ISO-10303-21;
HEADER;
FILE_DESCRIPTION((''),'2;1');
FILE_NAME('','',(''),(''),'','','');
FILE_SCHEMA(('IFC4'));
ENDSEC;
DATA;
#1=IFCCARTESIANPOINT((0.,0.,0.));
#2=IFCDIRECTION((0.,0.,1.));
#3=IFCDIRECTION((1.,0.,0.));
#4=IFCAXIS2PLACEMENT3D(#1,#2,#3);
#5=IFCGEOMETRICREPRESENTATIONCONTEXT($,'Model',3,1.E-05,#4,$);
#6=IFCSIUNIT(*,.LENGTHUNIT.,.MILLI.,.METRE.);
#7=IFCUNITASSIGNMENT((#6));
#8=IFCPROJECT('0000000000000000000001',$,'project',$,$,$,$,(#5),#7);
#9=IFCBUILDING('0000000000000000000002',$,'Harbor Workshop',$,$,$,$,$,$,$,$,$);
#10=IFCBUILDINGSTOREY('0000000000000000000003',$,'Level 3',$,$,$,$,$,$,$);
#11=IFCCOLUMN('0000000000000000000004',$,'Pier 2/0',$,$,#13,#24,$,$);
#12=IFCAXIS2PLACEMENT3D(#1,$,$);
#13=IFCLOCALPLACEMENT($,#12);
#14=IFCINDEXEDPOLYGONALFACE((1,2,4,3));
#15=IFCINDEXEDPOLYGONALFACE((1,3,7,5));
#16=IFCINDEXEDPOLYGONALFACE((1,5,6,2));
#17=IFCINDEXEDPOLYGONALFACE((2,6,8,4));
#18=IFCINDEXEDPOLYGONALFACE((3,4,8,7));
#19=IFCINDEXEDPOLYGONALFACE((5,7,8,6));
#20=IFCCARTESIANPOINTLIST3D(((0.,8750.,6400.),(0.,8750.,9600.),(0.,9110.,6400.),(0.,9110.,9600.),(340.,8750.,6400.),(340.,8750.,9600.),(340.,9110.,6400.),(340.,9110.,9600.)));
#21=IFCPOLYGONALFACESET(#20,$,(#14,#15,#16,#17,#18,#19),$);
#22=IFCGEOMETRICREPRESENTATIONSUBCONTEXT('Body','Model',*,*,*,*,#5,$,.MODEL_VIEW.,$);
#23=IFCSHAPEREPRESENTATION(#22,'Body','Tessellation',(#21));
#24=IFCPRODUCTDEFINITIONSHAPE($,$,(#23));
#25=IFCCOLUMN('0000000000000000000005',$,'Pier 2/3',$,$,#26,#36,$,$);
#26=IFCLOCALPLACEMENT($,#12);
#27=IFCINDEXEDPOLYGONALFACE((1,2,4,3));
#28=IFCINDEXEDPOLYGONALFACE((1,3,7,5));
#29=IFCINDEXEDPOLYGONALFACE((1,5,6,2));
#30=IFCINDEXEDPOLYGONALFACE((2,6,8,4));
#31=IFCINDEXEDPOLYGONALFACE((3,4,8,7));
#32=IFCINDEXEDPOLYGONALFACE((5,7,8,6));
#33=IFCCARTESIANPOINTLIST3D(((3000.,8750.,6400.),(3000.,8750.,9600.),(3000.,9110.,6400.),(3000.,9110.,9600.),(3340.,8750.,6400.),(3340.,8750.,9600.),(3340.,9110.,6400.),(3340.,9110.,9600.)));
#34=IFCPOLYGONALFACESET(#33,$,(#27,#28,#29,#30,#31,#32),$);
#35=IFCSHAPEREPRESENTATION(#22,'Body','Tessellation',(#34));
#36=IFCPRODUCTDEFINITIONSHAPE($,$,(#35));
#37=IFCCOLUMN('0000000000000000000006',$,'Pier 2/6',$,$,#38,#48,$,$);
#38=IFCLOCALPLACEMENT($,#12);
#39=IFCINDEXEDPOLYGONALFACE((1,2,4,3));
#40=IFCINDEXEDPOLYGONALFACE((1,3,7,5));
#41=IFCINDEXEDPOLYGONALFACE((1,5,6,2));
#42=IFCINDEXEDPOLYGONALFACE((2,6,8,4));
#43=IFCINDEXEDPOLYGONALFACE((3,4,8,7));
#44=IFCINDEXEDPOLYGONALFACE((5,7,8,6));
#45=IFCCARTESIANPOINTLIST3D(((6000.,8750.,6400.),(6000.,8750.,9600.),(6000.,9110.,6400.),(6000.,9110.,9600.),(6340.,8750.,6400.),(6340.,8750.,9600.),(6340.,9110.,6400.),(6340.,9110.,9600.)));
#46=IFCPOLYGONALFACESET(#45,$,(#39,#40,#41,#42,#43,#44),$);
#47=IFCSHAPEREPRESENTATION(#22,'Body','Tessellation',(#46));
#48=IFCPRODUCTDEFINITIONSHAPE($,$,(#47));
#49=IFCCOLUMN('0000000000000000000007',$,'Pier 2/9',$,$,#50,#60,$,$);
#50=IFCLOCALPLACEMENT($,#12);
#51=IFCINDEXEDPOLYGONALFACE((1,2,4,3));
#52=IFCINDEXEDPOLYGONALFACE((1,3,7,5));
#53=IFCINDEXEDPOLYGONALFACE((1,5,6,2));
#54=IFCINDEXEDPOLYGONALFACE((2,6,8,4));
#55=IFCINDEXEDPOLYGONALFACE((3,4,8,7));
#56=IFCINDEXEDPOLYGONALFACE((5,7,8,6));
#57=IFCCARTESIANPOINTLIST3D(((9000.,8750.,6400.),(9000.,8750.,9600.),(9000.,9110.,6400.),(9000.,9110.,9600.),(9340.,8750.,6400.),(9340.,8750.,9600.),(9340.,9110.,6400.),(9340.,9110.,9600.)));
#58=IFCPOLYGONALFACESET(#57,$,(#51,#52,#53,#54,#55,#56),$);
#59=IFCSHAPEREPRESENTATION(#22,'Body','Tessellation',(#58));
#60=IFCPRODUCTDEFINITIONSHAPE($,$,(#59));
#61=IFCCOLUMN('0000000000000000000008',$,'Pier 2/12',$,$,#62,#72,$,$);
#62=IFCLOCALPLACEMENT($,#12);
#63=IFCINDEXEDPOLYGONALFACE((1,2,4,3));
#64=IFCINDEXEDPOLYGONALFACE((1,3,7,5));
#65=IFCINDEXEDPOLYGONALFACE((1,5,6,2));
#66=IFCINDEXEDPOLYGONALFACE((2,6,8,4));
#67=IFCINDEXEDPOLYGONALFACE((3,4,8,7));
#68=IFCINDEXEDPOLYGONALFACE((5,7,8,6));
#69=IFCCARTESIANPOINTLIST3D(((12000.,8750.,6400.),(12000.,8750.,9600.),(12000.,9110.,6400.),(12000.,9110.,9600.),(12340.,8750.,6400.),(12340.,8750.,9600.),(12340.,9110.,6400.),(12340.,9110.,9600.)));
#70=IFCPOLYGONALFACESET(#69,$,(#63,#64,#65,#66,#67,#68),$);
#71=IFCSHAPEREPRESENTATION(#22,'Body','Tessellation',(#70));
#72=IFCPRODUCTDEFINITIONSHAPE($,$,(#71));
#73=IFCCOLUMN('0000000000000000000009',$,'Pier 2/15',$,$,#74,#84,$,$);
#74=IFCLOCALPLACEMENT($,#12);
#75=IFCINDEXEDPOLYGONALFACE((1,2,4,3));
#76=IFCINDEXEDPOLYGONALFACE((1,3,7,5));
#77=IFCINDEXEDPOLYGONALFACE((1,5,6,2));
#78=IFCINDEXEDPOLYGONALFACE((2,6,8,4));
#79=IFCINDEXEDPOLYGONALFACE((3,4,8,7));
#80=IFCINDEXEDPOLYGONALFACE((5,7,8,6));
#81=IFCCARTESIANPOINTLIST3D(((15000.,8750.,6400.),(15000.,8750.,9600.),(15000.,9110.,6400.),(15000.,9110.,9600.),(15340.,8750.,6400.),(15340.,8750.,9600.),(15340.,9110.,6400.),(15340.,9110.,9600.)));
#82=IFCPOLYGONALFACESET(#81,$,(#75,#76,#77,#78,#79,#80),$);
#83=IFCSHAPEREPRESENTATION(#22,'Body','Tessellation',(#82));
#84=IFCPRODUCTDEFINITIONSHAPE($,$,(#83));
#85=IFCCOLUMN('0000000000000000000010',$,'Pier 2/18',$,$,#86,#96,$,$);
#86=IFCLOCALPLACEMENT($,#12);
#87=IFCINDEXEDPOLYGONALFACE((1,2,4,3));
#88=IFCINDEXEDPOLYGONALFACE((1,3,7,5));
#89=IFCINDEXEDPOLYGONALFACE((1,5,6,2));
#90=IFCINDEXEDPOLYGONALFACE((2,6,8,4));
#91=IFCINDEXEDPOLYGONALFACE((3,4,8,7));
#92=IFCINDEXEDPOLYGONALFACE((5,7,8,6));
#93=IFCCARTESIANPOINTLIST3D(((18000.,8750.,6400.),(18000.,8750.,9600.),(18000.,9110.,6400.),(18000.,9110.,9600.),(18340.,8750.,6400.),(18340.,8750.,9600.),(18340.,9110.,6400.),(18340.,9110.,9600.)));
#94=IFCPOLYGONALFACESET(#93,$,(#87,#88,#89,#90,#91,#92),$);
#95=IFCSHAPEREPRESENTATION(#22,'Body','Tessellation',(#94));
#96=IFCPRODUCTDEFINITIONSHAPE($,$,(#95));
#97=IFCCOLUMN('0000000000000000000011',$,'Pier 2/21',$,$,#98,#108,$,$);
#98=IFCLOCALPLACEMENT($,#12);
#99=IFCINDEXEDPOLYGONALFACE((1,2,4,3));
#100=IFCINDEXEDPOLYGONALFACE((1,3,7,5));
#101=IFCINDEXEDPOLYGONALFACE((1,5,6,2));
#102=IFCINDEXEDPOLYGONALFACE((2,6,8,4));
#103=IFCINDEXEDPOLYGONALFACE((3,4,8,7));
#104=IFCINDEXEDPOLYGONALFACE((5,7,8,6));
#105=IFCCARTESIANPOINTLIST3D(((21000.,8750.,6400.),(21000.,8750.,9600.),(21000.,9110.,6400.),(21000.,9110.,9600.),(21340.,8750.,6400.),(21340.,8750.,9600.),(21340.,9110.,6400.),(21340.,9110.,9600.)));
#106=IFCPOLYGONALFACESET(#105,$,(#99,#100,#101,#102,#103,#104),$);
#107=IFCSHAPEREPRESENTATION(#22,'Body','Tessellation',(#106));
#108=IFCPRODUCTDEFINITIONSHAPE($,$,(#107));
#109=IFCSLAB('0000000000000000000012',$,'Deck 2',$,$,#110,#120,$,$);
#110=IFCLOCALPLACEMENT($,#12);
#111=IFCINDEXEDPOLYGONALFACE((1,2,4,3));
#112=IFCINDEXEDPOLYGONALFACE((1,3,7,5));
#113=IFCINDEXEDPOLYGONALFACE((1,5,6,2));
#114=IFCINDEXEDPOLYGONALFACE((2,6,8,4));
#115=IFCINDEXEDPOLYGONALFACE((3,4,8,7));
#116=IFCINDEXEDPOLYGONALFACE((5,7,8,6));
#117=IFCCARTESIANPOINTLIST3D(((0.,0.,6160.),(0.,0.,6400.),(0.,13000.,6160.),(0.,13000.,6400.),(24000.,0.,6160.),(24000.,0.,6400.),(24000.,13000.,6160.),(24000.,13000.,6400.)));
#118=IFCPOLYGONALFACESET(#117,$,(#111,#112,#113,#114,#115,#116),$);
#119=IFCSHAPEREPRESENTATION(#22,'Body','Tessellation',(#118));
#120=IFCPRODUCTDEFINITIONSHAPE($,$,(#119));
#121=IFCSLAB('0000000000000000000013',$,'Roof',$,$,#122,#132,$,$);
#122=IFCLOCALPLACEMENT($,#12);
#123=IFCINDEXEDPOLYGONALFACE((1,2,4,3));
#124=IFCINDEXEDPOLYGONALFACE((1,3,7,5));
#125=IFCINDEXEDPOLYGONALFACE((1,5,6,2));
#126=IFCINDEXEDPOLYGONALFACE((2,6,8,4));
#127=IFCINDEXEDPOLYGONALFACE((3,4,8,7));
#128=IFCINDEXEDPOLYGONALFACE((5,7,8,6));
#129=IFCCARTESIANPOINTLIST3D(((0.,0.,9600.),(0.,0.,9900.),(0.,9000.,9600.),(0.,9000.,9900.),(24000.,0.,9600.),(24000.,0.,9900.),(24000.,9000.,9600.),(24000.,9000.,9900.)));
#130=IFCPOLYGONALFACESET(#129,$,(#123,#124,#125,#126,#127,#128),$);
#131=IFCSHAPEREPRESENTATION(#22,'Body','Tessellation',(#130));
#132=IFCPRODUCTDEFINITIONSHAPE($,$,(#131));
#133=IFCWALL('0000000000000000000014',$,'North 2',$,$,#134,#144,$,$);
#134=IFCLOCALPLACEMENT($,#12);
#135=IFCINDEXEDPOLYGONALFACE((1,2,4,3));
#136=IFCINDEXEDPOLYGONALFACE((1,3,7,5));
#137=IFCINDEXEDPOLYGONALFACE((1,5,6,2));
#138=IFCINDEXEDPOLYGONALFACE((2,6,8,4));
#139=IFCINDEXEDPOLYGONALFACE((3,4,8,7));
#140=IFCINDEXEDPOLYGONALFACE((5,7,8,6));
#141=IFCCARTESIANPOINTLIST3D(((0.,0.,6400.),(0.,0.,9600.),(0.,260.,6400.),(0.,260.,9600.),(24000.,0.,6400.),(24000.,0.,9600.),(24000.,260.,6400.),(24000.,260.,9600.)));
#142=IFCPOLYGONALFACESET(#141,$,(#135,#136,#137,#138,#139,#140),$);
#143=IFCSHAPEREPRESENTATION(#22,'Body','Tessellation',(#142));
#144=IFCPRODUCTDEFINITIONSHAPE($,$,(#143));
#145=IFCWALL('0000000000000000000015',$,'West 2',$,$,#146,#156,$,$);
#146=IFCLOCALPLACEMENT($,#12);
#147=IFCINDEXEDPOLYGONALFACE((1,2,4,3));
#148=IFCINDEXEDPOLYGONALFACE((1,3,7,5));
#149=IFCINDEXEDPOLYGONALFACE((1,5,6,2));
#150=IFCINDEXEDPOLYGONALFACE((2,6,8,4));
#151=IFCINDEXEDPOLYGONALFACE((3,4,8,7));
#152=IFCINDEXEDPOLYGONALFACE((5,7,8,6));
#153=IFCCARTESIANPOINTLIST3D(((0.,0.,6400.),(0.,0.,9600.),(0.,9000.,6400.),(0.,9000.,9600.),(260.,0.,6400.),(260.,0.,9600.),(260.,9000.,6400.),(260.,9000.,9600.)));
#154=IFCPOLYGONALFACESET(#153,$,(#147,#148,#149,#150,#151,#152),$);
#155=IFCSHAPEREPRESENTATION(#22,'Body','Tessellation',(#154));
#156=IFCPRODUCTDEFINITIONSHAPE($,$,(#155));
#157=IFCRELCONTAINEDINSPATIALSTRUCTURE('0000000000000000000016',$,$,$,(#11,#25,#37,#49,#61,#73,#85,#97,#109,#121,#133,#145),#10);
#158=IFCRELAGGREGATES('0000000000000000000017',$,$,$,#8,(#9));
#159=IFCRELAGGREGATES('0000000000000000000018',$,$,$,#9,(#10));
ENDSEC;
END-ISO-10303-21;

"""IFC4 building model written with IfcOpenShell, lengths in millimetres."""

from ifc_helpers import new_model, si_unit, frame, origin_with_axes, place, context, subcontext, project, spatial, indexed_curve, outline, extrude, element, save


model = new_model("IFC4")

# Units and contexts
model_context = context("Model", 3, precision=1e-05, world=origin_with_axes())
body_context = subcontext(model_context, "Body", "Model", "MODEL_VIEW")
ifc_project = project(units=[si_unit("LENGTHUNIT", "METRE", prefix="MILLI")], contexts=[model_context])

# Building, storey
building = spatial("IfcBuilding", under=ifc_project, Name="Harbor Workshop")
storey = spatial("IfcBuildingStorey", under=building, Name="Level 3")

# Columns
for number, where, z_axis, x_axis, name in (
    (1, (0.0, 8750.0, 6400.0), (0.0, 0.0, 1.0), (1.0, 0.0, 0.0), "Pier 2/0"),
    (2, (3000.0, 8750.0, 6400.0), (0.0, 0.0, 1.0), (1.0, 0.0, 0.0), "Pier 2/3"),
    (3, (6000.0, 8750.0, 6400.0), (0.0, 0.0, 1.0), (1.0, 0.0, 0.0), "Pier 2/6"),
    (4, (9000.0, 8750.0, 6400.0), (0.0, 0.0, 1.0), (1.0, 0.0, 0.0), "Pier 2/9"),
    (5, (12000.0, 8750.0, 6400.0), (0.0, 0.0, 1.0), (1.0, 0.0, 0.0), "Pier 2/12"),
    (6, (15000.0, 8750.0, 6400.0), (0.0, 0.0, 1.0), (1.0, 0.0, 0.0), "Pier 2/15"),
    (7, (18000.0, 8750.0, 6400.0), (0.0, 0.0, 1.0), (1.0, 0.0, 0.0), "Pier 2/18"),
    (8, (21000.0, 8750.0, 6400.0), (0.0, 0.0, 1.0), (1.0, 0.0, 0.0), "Pier 2/21"),
):
    element("IfcColumn", number, at=place(None, frame(where, z_axis=z_axis, x_axis=x_axis)), inside=storey, Name=name, context=body_context, shape_type="SweptSolid", body=[
        extrude(outline(indexed_curve([(0.0, 0.0), (0.0, 360.0), (340.0, 360.0), (340.0, 0.0), (0.0, 0.0)], self_intersect=False)), origin_with_axes(), (0.0, 0.0, 1.0), 3200.0),
    ])

# Slabs
slab_1_placement = place(None, frame((0.0, 0.0, 6160.0), z_axis=(0.0, 0.0, 1.0), x_axis=(1.0, 0.0, 0.0)))
element("IfcSlab", 9, at=slab_1_placement, inside=storey, Name="Deck 2", context=body_context, shape_type="SweptSolid", body=[
    extrude(outline(indexed_curve([(0.0, 0.0), (0.0, 13000.0), (24000.0, 13000.0), (24000.0, 0.0), (0.0, 0.0)], self_intersect=False)), origin_with_axes(), (0.0, 0.0, 1.0), 240.0),
])
slab_2_placement = place(None, frame((0.0, 0.0, 9600.0), z_axis=(0.0, 0.0, 1.0), x_axis=(1.0, 0.0, 0.0)))
element("IfcSlab", 10, at=slab_2_placement, inside=storey, Name="Roof", context=body_context, shape_type="SweptSolid", body=[
    extrude(outline(indexed_curve([(0.0, 0.0), (0.0, 9000.0), (24000.0, 9000.0), (24000.0, 0.0), (0.0, 0.0)], self_intersect=False)), origin_with_axes(), (0.0, 0.0, 1.0), 300.0),
])

# Walls
wall_1_placement = place(None, frame((0.0, 0.0, 6400.0), z_axis=(0.0, 0.0, 1.0), x_axis=(1.0, 0.0, 0.0)))
element("IfcWall", 11, at=wall_1_placement, inside=storey, Name="North 2", context=body_context, shape_type="SweptSolid", body=[
    extrude(outline(indexed_curve([(0.0, 0.0), (0.0, 260.0), (24000.0, 260.0), (24000.0, 0.0), (0.0, 0.0)], self_intersect=False)), origin_with_axes(), (0.0, 0.0, 1.0), 3200.0),
])
wall_2_placement = place(None, frame((260.0, 0.0, 6400.0), z_axis=(0.0, 0.0, 1.0), x_axis=(0.0, 1.0, 0.0)))
element("IfcWall", 12, at=wall_2_placement, inside=storey, Name="West 2", context=body_context, shape_type="SweptSolid", body=[
    extrude(outline(indexed_curve([(0.0, 0.0), (0.0, 260.0), (9000.0, 260.0), (9000.0, 0.0), (0.0, 0.0)], self_intersect=False)), origin_with_axes(), (0.0, 0.0, 1.0), 3200.0),
])

save(model, "model.ifc")
